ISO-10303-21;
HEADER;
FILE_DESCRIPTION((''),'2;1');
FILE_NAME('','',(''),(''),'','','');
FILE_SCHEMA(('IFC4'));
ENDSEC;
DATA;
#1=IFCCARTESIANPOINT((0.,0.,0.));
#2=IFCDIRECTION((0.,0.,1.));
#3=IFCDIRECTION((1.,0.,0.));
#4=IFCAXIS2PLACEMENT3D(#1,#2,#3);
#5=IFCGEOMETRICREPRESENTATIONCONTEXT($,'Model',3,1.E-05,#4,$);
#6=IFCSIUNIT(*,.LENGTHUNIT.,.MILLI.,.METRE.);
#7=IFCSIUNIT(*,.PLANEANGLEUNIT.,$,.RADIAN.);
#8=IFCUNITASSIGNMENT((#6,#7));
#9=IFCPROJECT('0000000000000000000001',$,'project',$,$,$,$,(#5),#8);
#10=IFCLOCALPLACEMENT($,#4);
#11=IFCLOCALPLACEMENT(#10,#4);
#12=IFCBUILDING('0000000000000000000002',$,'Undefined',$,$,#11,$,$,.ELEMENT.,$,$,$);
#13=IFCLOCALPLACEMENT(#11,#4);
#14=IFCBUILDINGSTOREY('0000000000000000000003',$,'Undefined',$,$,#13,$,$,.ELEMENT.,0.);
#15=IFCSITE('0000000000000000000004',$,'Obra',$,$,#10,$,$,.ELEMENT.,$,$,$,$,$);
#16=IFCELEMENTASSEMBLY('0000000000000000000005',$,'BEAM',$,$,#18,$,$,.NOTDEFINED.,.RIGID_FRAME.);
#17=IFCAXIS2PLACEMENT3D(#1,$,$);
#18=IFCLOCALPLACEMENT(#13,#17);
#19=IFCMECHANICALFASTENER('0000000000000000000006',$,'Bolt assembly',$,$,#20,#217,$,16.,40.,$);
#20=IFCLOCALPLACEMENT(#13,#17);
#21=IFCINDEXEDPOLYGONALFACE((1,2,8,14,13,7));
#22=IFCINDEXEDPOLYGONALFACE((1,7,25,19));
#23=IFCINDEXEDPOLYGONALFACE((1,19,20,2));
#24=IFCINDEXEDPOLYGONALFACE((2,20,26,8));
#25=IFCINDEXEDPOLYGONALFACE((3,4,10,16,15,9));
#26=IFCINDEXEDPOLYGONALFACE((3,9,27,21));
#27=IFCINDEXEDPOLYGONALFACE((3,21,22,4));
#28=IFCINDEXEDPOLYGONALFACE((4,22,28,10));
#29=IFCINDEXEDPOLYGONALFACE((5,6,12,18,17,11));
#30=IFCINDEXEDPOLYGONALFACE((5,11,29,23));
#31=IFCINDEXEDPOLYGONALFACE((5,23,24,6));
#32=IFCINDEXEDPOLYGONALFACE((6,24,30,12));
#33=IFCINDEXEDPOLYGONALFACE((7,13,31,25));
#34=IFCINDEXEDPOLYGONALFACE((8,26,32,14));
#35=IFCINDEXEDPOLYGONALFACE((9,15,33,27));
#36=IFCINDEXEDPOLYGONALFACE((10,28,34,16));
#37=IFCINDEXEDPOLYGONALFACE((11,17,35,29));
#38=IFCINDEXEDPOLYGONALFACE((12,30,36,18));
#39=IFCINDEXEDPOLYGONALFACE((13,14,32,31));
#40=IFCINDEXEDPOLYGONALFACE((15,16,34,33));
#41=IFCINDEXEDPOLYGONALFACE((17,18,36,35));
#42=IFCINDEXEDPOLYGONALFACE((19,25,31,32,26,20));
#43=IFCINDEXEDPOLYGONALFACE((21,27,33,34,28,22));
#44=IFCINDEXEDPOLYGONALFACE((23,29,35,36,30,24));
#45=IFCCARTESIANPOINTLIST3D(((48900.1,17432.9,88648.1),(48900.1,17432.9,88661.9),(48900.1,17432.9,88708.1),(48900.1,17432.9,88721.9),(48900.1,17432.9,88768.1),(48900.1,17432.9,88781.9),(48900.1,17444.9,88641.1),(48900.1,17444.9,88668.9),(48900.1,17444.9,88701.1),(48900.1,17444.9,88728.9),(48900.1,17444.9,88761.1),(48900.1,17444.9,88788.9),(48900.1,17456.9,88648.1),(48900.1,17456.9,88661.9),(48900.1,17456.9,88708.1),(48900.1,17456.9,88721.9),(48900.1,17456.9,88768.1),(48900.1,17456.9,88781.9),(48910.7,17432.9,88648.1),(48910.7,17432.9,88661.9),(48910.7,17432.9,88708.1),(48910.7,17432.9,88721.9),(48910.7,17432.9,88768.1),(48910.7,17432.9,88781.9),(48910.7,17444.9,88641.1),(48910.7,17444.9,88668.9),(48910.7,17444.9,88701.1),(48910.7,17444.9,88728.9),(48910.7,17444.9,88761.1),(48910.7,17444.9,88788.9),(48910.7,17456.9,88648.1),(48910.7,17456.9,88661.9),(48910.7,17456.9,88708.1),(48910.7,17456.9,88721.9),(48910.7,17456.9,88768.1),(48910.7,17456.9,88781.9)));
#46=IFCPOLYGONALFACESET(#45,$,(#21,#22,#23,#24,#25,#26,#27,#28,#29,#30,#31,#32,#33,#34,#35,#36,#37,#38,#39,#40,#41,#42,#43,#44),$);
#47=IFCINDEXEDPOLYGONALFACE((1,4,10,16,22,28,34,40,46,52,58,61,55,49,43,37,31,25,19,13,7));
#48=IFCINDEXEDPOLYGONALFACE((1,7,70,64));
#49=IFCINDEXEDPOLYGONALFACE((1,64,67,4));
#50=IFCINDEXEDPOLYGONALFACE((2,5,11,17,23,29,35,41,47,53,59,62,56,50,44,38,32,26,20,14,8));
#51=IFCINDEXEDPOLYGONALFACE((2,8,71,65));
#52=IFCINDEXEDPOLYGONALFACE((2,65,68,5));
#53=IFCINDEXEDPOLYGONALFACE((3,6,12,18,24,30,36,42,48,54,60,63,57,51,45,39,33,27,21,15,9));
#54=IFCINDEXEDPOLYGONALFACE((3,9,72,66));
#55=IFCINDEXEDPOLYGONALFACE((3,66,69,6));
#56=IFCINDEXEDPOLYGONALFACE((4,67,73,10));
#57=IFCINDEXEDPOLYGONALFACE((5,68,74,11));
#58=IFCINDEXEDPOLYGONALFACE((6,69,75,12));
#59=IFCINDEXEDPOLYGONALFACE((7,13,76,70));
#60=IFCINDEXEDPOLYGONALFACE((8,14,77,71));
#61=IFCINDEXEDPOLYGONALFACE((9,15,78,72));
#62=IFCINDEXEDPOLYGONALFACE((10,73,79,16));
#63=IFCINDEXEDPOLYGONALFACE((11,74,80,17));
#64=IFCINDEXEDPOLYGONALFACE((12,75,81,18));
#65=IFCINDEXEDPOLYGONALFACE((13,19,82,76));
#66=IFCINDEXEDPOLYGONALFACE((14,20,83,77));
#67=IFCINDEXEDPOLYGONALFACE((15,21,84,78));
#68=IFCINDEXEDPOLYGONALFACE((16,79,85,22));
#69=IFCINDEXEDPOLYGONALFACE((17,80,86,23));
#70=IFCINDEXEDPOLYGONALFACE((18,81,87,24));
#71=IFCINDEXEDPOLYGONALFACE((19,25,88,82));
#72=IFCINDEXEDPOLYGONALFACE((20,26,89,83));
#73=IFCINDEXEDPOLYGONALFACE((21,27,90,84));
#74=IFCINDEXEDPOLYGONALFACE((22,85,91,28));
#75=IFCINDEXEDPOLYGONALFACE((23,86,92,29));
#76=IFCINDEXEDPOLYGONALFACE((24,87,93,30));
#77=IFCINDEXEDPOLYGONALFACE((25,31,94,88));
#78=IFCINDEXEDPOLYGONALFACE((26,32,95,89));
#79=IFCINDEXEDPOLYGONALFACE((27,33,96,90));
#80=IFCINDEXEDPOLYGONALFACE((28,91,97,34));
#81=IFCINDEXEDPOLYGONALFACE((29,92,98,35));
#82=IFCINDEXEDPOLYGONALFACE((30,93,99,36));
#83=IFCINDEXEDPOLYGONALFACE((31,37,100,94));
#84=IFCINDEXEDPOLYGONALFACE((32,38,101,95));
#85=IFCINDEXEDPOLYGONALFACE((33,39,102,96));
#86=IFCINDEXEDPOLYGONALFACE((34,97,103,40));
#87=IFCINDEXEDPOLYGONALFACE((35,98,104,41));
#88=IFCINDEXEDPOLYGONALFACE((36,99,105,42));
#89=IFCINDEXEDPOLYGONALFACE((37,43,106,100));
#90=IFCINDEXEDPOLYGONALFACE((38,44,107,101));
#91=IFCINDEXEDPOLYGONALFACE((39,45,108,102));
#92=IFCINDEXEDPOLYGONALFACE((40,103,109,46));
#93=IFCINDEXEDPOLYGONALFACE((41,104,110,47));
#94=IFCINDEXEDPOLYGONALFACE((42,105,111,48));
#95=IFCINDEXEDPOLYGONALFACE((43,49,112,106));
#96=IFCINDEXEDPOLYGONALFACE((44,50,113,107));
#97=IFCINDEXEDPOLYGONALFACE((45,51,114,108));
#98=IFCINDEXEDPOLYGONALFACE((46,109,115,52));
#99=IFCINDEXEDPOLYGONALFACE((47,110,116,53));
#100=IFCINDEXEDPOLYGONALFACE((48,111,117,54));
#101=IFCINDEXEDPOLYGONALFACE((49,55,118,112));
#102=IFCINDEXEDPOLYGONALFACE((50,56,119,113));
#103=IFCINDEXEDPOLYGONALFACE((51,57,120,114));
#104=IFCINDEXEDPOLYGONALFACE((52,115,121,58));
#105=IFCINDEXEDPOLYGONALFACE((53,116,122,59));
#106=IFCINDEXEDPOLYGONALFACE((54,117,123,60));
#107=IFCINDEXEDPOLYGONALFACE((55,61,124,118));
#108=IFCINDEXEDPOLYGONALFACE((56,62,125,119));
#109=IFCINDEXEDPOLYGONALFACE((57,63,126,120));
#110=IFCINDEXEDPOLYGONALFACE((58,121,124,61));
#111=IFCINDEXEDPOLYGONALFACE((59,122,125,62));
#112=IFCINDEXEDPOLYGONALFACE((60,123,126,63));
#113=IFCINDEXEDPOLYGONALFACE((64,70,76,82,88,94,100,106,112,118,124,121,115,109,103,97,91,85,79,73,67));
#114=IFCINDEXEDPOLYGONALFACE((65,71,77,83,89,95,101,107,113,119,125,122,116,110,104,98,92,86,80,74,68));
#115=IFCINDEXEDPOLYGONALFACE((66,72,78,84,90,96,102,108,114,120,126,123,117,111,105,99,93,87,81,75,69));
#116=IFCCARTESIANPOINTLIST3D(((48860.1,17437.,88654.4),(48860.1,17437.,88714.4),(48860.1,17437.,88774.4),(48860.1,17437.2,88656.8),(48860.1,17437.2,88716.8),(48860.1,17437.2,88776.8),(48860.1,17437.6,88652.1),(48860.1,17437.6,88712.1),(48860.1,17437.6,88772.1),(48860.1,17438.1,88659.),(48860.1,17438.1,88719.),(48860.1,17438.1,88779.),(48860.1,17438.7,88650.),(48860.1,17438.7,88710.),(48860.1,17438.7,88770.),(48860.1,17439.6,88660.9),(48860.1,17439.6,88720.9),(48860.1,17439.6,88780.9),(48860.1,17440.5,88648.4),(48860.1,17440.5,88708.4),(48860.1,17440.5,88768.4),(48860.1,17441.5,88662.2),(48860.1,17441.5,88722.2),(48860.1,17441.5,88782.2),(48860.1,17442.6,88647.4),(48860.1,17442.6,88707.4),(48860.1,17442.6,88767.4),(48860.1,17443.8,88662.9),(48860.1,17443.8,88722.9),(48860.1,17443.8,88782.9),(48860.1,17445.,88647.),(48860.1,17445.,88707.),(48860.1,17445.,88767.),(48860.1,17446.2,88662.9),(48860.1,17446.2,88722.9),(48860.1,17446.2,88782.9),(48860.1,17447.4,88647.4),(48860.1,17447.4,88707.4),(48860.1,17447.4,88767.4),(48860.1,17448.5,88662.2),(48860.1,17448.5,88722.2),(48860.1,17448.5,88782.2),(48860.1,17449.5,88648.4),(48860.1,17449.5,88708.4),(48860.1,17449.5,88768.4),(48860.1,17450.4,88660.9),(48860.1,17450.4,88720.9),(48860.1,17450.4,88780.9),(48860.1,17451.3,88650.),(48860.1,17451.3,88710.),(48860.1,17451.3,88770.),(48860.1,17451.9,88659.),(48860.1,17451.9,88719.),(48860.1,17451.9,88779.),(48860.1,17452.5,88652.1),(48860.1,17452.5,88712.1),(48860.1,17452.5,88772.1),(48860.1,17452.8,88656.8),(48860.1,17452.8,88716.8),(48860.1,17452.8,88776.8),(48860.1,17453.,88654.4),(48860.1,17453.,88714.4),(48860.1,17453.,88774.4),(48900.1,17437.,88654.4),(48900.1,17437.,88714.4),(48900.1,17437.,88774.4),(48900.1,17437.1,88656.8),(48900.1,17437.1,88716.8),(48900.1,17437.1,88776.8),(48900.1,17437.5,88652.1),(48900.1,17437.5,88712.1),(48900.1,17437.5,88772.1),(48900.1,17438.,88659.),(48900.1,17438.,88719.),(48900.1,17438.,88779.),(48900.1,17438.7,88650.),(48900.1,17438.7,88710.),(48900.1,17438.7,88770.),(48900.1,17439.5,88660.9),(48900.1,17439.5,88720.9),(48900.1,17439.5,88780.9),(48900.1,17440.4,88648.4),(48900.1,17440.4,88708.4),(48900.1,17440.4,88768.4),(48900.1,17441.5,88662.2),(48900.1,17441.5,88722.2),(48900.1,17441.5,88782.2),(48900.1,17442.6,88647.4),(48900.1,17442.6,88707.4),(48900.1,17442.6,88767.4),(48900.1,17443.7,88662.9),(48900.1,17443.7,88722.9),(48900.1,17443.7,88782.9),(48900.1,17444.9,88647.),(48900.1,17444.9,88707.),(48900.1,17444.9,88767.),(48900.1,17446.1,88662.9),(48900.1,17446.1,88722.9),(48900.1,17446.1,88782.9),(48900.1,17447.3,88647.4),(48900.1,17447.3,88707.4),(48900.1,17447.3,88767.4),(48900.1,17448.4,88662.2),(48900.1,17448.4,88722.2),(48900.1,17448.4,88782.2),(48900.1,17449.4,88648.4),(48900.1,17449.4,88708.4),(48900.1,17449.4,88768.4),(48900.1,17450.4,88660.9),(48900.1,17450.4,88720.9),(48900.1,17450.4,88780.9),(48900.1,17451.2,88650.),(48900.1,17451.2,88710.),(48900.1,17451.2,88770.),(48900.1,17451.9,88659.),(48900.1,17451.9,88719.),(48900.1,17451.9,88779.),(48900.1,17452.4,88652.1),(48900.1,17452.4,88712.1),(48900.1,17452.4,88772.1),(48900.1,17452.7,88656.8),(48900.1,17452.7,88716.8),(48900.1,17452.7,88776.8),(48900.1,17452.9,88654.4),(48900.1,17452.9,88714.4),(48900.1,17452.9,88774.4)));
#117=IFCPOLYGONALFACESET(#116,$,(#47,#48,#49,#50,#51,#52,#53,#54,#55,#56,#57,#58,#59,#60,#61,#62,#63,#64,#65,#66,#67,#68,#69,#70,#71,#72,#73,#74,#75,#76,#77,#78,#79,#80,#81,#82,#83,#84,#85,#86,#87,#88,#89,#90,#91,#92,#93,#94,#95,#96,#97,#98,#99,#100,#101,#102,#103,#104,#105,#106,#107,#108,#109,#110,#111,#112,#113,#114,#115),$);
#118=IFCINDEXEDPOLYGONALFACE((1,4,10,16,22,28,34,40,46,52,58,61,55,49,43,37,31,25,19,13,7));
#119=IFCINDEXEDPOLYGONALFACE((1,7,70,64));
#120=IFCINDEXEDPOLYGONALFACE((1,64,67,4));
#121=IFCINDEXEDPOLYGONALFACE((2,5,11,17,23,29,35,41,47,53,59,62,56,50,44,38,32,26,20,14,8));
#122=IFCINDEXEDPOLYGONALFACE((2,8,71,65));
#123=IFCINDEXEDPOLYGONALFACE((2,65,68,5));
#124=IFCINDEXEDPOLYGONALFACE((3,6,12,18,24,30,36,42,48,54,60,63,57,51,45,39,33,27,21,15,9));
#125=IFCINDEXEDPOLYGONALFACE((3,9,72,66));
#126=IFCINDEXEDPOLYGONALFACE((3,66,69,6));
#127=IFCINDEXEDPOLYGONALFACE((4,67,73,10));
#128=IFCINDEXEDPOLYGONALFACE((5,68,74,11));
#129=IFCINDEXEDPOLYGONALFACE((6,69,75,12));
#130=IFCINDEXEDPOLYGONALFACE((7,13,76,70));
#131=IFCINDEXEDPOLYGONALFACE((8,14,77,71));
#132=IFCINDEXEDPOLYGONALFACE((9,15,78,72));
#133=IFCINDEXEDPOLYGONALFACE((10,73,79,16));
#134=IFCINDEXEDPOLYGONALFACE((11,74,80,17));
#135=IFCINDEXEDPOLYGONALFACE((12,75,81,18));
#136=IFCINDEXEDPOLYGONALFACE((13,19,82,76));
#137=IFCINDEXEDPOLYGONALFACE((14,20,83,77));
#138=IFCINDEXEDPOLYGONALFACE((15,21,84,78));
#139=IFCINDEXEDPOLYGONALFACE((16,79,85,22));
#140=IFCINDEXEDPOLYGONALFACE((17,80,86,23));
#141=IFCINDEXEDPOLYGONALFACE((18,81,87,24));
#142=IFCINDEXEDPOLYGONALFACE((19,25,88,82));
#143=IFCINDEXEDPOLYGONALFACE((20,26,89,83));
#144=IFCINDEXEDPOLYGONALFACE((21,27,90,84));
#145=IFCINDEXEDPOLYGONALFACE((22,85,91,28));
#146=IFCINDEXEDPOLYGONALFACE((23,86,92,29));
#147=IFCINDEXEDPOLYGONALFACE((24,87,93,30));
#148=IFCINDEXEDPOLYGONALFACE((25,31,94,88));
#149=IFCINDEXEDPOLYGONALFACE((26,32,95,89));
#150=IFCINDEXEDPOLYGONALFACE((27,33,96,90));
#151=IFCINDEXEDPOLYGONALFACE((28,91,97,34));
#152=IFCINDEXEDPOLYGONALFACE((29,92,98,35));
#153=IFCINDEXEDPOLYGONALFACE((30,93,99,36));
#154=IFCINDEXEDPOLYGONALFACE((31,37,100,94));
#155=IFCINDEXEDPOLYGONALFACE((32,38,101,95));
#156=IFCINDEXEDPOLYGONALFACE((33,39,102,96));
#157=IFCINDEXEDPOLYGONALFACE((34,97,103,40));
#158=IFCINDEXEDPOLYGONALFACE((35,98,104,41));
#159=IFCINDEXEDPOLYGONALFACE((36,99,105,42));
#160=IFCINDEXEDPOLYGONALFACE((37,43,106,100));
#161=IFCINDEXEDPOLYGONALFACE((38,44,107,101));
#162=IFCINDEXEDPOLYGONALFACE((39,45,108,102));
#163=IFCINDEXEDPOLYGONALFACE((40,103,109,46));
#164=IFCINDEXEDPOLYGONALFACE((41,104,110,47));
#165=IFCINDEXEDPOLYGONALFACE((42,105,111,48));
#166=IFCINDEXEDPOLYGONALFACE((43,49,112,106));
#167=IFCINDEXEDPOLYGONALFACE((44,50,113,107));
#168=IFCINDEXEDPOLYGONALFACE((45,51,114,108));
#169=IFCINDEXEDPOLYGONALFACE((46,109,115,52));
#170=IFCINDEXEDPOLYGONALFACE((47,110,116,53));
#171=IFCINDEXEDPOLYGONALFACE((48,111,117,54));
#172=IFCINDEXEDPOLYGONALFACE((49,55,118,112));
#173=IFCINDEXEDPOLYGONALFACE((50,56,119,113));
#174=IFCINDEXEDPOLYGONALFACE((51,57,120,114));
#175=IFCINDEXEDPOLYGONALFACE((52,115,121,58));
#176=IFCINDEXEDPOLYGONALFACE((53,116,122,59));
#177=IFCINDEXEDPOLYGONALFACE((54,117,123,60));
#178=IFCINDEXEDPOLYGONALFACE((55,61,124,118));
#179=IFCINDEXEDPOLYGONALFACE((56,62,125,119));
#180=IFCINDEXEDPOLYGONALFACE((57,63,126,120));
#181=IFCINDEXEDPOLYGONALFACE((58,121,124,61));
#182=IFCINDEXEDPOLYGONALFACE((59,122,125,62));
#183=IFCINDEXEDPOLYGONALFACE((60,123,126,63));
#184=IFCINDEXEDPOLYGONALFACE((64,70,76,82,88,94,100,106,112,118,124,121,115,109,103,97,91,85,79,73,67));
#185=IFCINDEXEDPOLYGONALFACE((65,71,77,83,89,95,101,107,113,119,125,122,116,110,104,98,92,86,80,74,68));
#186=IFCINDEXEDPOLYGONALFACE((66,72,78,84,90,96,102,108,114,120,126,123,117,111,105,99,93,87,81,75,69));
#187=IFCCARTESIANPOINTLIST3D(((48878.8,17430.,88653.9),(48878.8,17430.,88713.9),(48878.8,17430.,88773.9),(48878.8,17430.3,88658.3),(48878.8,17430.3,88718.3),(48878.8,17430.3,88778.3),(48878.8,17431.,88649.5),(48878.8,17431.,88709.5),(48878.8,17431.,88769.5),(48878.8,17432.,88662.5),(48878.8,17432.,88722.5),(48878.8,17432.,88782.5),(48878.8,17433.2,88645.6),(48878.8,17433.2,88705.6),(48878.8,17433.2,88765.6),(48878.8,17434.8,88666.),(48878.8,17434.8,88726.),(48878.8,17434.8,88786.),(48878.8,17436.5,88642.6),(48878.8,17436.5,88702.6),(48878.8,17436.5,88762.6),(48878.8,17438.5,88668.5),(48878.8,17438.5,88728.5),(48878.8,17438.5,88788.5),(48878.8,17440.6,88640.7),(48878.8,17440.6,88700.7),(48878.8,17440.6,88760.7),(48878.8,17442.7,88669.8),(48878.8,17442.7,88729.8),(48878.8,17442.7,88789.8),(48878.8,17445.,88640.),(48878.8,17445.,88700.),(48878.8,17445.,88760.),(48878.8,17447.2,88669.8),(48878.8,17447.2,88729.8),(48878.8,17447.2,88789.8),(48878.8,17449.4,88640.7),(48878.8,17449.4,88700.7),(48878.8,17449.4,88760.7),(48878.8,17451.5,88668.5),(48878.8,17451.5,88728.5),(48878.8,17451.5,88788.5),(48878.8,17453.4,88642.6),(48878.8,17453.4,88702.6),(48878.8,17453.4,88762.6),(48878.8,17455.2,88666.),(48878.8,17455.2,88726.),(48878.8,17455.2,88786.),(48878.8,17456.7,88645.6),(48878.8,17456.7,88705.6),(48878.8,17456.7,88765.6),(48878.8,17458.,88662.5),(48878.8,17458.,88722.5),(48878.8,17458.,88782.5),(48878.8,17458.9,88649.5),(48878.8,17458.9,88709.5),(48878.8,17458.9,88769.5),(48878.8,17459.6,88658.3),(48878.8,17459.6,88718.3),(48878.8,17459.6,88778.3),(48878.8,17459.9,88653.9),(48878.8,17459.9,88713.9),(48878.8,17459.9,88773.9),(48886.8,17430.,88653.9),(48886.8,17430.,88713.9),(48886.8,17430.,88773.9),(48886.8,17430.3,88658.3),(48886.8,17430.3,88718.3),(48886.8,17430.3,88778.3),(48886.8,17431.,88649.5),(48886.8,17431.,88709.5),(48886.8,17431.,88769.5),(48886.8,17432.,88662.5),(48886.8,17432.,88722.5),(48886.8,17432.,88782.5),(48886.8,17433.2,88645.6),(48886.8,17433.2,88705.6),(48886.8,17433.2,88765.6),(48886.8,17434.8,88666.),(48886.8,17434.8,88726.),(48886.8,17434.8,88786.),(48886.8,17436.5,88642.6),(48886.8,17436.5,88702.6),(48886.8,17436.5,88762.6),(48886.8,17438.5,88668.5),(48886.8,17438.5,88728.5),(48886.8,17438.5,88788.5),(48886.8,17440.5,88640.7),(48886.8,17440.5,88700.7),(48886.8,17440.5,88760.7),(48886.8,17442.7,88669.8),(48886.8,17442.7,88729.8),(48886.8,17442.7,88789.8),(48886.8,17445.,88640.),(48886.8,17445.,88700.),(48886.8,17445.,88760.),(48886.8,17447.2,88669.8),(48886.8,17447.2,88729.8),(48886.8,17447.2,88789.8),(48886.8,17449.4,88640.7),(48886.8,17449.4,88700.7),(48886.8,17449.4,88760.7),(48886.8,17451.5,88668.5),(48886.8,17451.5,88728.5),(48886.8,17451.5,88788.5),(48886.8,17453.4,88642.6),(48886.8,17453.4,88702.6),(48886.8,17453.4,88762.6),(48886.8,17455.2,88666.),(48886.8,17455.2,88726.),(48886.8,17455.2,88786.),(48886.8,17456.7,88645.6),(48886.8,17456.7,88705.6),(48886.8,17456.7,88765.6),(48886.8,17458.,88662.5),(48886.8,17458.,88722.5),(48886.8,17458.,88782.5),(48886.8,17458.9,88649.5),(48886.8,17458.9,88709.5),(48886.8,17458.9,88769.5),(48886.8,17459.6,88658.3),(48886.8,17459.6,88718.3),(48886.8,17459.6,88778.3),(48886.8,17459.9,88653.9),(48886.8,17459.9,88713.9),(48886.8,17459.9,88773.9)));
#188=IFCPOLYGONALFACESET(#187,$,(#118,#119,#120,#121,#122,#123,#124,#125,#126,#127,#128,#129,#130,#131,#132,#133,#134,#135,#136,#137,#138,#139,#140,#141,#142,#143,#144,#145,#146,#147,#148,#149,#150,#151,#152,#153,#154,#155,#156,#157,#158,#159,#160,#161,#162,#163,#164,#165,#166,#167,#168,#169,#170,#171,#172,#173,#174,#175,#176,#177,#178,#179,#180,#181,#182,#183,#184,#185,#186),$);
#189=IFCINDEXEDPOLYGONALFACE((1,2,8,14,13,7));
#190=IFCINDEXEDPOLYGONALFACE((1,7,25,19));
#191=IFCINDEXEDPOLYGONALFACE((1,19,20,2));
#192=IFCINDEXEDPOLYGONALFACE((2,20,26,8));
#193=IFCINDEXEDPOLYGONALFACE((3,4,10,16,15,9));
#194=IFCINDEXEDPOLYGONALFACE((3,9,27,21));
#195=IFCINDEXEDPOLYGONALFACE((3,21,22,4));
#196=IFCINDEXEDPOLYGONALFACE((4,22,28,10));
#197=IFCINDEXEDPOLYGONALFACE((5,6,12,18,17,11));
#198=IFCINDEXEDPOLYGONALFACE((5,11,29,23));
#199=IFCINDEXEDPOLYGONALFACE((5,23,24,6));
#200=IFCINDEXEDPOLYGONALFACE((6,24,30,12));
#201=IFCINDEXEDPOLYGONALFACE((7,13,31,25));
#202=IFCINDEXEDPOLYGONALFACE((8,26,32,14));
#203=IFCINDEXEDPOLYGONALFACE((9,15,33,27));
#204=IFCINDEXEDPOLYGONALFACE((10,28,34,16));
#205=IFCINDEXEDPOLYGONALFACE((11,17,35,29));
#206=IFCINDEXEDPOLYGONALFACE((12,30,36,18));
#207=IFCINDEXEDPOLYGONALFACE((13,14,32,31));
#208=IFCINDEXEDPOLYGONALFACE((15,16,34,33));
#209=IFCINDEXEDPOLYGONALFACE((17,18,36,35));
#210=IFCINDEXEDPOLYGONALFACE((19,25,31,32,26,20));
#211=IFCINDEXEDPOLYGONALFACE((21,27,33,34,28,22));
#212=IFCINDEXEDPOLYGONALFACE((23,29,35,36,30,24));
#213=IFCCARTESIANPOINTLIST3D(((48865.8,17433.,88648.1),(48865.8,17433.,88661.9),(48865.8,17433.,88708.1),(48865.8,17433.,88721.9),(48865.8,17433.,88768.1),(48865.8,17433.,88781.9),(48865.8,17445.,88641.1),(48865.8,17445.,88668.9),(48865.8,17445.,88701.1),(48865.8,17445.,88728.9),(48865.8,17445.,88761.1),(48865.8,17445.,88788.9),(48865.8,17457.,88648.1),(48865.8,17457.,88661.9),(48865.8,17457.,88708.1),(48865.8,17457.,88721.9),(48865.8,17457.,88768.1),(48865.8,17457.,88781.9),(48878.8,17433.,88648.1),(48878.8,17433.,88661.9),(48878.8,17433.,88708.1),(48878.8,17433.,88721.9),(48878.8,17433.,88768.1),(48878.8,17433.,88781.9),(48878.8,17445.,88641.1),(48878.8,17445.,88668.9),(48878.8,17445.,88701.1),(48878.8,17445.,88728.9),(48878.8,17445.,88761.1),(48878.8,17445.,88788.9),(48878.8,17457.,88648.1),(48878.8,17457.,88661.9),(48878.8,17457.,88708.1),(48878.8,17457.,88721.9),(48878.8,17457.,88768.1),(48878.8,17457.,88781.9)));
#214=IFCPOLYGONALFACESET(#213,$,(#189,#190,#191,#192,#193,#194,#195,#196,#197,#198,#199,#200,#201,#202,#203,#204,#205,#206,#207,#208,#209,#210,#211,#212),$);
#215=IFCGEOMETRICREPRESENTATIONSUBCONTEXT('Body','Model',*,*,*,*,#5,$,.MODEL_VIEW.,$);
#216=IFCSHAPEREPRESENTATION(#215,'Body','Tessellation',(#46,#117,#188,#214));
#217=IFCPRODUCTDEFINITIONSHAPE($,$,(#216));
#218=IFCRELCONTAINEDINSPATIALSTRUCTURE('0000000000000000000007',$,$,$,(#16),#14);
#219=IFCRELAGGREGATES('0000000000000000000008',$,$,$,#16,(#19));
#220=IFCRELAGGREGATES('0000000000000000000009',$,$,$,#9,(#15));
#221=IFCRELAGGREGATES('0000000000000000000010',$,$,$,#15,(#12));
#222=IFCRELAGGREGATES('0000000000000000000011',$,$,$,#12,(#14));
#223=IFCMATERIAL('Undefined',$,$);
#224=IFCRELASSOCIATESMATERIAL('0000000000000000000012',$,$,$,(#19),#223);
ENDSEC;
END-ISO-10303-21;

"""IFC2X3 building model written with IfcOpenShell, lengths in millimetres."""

from ifc_helpers import new_model, si_unit, frame, origin_with_axes, origin_2d_with_axis, place, context, subcontext, project, spatial, polyline, circle, outline, extrude, source, transform, mapped, material, element, aggregate, save


model = new_model("IFC2X3")

# Units and contexts
model_context = context("Model", 3, precision=1e-05, world=origin_with_axes())
body_context = subcontext(model_context, "Body", "Model", "MODEL_VIEW")
ifc_project = project(units=[si_unit("LENGTHUNIT", "METRE", prefix="MILLI"), si_unit("PLANEANGLEUNIT", "RADIAN")], contexts=[model_context])

# Site, building, storey
site_placement = place(None, origin_with_axes())
site = spatial("IfcSite", under=ifc_project, at=site_placement, Name="Obra", CompositionType="ELEMENT")
building_placement = place(site_placement, origin_with_axes())
building = spatial("IfcBuilding", under=site, at=building_placement, Name="Undefined", CompositionType="ELEMENT")
storey_placement = place(building_placement, origin_with_axes())
storey = spatial("IfcBuildingStorey", under=building, at=storey_placement, Name="Undefined", CompositionType="ELEMENT", Elevation=0.0)

# Element assembly
ifc_material_1 = material(Name="Undefined")
assembly_1_placement = place(storey_placement, origin_with_axes())
assembly_1 = element("IfcElementAssembly", 1, at=assembly_1_placement, inside=storey, Name="BEAM", AssemblyPlace="NOTDEFINED", PredefinedType="RIGID_FRAME")

# Mechanical fastener
shared_shape_1 = source(origin_with_axes(), body_context, "Body", "SweptSolid", [
    extrude(outline(polyline([(13.9, 0.0), (6.9, 12.0), (-6.9, 12.0), (-13.9, 0.0), (-6.9, -12.0), (6.9, -12.0), (13.9, 0.0)])), frame((0.0, -19.7, 0.0), z_axis=(0.0, 1.0, 0.0), x_axis=(1.0, 0.0, 0.0)), (0.0, 0.0, 1.0), 10.6),
    extrude(circle(Radius=8.0, at=origin_2d_with_axis()), frame((0.0, -9.1, 0.0), z_axis=(0.0, 1.0, 0.0), x_axis=(1.0, 0.0, 0.0)), (0.0, 0.0, 1.0), 40.0),
    extrude(circle(Radius=15.0, at=origin_2d_with_axis()), frame((0.0, 4.2, 0.0), z_axis=(0.0, 1.0, 0.0), x_axis=(1.0, 0.0, 0.0)), (0.0, 0.0, 1.0), 8.0),
    extrude(outline(polyline([(13.9, 0.0), (6.9, 12.0), (-6.9, 12.0), (-13.9, 0.0), (-6.9, -12.0), (6.9, -12.0), (13.9, 0.0)])), frame((0.0, 12.2, 0.0), z_axis=(0.0, 1.0, 0.0), x_axis=(1.0, 0.0, 0.0)), (0.0, 0.0, 1.0), 13.0),
])
mechanical_fastener_1_placement = place(assembly_1_placement, frame((48890.9, 17395.0, 88835.0), z_axis=(0.001649, 0.999999, 0.0), x_axis=(0.0, 0.0, -1.0)))
mechanical_fastener_1 = element("IfcMechanicalFastener", 2, at=mechanical_fastener_1_placement, material=ifc_material_1, Name="Bolt assembly", NominalDiameter=16.0, NominalLength=40.0, context=body_context, shape_type="MappedRepresentation", body=[
    mapped(shared_shape_1, transform((60.0, 0.0, 50.0))),
    mapped(shared_shape_1, transform((120.0, 0.0, 50.0))),
    mapped(shared_shape_1, transform((180.0, 0.0, 50.0))),
])
aggregate(assembly_1, [mechanical_fastener_1])

save(model, "model.ifc")
